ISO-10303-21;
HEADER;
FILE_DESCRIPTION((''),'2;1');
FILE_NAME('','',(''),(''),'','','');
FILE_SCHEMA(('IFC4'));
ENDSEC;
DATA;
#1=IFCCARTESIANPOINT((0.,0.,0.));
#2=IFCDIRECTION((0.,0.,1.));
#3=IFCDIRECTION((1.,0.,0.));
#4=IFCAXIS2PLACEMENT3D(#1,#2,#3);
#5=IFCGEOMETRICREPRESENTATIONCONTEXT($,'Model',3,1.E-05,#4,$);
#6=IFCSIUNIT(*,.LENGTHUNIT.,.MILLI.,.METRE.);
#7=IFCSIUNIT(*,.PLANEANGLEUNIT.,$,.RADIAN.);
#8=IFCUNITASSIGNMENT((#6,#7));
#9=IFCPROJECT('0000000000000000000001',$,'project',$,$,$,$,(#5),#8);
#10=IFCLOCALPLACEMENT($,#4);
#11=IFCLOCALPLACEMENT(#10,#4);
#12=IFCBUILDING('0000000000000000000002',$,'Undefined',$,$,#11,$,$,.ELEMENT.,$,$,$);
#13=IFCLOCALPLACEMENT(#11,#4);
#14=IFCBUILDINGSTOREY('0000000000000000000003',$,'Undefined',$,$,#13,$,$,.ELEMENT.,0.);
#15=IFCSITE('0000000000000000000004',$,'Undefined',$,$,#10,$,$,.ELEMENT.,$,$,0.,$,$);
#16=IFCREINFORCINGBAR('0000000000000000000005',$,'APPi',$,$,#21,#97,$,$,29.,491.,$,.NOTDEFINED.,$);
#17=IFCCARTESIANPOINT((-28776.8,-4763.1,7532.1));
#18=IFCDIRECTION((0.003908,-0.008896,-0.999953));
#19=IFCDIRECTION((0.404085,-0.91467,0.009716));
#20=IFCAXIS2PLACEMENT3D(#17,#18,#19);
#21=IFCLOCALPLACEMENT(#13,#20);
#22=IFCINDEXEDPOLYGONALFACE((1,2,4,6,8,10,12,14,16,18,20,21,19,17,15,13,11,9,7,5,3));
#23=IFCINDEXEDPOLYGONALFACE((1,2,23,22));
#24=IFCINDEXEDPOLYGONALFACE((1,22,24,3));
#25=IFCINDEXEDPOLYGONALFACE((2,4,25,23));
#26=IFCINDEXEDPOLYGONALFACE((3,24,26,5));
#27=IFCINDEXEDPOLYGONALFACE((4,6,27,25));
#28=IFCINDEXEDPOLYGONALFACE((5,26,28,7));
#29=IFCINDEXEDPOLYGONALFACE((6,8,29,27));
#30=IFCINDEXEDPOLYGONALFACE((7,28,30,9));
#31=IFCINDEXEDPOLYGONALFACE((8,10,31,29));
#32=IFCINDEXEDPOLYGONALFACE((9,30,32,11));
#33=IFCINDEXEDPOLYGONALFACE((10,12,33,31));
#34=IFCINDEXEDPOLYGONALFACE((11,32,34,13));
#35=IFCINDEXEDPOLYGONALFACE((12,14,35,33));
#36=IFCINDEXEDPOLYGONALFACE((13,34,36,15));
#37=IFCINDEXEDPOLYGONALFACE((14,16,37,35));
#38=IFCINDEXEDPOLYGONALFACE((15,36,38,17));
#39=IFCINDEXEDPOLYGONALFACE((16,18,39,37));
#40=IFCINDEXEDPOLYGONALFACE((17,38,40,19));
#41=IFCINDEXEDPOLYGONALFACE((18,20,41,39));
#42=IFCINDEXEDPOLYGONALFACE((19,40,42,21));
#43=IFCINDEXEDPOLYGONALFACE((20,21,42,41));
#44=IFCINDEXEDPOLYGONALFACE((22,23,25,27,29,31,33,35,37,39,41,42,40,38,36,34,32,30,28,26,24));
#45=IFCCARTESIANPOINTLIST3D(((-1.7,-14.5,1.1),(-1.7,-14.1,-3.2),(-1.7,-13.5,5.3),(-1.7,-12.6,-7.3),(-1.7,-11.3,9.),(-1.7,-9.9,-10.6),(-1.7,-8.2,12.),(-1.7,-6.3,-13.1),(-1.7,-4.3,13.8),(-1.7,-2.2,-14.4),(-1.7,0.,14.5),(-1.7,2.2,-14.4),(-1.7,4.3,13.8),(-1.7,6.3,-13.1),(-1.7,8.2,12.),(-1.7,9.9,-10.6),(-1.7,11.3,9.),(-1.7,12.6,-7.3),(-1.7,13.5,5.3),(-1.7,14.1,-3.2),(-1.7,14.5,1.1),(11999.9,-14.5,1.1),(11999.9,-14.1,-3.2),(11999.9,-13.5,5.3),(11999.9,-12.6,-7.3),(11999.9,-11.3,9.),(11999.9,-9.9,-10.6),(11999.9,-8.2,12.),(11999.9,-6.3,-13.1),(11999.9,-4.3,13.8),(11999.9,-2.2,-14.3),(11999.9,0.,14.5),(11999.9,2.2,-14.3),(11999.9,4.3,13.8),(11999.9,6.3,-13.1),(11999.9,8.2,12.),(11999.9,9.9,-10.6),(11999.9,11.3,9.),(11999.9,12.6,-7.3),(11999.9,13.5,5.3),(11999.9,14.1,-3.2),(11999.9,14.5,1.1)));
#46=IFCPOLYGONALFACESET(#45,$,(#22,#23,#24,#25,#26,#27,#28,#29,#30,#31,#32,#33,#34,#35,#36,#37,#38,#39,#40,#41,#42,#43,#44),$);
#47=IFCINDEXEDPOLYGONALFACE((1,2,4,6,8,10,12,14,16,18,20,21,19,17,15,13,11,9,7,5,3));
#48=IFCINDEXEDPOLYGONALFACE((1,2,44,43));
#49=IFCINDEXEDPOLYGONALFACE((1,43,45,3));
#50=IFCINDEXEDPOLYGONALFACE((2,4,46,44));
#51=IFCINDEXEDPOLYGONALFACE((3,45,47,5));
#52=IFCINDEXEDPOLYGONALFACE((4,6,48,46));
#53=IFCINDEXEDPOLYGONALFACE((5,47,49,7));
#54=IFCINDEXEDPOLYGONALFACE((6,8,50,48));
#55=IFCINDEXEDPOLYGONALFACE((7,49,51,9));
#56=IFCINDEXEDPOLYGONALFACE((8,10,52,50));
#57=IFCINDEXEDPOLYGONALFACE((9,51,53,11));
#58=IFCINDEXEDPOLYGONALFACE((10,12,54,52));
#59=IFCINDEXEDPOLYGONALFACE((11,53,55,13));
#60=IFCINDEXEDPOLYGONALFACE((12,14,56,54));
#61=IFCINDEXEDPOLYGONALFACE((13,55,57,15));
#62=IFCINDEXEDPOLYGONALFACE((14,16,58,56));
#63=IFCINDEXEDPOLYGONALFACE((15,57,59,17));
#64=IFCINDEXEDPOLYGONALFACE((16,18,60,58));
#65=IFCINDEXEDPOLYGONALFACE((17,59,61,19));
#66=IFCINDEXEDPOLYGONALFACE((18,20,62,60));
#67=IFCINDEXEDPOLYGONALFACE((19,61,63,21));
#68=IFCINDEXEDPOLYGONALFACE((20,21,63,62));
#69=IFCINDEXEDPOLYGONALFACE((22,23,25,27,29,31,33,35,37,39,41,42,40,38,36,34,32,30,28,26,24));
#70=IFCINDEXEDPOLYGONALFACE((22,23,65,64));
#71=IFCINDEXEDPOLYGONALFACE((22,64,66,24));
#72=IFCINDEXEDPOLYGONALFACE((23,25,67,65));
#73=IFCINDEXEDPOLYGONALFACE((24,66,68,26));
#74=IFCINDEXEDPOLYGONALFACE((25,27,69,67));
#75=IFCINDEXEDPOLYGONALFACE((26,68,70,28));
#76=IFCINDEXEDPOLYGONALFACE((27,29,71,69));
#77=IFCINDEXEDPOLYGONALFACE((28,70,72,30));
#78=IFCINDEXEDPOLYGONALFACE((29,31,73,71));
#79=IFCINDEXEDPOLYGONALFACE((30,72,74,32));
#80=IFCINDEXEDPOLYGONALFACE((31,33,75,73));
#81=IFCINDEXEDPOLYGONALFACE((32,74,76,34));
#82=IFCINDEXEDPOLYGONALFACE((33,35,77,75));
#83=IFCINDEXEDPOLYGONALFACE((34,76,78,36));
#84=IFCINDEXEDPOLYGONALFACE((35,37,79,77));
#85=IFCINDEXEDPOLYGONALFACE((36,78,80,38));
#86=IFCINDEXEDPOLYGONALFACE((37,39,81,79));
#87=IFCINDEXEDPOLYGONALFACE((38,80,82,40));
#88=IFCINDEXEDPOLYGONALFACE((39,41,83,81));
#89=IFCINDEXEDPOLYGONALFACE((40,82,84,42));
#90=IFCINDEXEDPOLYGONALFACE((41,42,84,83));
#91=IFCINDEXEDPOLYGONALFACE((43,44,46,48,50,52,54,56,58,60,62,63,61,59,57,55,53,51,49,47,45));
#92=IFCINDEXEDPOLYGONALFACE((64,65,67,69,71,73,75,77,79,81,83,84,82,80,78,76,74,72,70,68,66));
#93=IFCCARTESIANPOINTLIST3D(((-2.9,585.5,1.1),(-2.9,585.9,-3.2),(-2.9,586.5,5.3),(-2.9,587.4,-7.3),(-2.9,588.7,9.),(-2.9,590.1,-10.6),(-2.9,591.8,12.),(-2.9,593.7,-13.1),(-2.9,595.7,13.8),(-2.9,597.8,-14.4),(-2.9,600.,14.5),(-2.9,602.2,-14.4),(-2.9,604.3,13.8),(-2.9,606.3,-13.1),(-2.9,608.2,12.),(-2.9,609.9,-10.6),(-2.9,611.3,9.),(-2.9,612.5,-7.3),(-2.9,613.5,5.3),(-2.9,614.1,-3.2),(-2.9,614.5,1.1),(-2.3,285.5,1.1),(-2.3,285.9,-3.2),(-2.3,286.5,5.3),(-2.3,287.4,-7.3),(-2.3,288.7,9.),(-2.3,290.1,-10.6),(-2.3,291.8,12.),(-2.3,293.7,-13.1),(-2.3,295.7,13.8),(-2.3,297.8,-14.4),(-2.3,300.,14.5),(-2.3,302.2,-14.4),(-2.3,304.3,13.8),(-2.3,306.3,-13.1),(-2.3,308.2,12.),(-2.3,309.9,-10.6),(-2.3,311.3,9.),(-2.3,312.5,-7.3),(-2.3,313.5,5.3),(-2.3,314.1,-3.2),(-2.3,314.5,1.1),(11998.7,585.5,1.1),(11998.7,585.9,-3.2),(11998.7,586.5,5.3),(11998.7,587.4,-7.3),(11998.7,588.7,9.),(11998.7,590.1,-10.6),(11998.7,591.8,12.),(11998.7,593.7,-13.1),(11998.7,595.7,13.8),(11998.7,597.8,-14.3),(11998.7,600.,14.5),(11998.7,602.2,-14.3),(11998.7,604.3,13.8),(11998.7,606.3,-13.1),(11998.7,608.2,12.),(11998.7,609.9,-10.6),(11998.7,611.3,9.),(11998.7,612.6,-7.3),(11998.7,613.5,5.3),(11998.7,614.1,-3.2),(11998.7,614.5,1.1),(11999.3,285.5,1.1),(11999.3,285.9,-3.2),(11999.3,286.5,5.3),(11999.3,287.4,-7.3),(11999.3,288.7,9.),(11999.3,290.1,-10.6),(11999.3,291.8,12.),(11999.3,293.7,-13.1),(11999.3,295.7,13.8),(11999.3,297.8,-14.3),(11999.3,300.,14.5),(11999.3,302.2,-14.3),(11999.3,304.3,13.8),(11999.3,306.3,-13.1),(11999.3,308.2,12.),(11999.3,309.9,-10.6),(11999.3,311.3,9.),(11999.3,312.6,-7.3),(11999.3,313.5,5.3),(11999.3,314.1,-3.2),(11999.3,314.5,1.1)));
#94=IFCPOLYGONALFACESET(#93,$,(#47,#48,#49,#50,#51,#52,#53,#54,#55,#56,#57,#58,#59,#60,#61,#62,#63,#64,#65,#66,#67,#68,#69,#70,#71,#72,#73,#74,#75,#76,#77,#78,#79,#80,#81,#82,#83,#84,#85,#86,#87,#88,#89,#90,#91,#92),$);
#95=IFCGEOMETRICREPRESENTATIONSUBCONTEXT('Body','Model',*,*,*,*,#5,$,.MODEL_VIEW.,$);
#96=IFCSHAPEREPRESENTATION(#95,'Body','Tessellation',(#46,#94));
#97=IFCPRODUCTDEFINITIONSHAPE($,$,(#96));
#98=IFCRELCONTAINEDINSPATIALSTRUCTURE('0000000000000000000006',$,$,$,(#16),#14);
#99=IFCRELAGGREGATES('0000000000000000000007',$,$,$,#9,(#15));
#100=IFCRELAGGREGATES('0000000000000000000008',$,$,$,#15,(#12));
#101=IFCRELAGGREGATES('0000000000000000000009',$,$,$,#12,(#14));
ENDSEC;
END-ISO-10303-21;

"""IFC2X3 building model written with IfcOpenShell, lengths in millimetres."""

from ifc_helpers import new_model, entity, si_unit, frame, origin_with_axes, place, context, subcontext, project, spatial, source, transform, mapped, element, save


model = new_model("IFC2X3")

# Units and contexts
model_context = context("Model", 3, precision=1e-05, world=origin_with_axes())
body_context = subcontext(model_context, "Body", "Model", "MODEL_VIEW")
ifc_project = project(units=[si_unit("LENGTHUNIT", "METRE", prefix="MILLI"), si_unit("PLANEANGLEUNIT", "RADIAN")], contexts=[model_context])

# Site, building, storey
site_placement = place(None, origin_with_axes())
site = spatial("IfcSite", under=ifc_project, at=site_placement, Name="Undefined", CompositionType="ELEMENT", RefElevation=0.0)
building_placement = place(site_placement, origin_with_axes())
building = spatial("IfcBuilding", under=site, at=building_placement, Name="Undefined", CompositionType="ELEMENT")
storey_placement = place(building_placement, origin_with_axes())
storey = spatial("IfcBuildingStorey", under=building, at=storey_placement, Name="Undefined", CompositionType="ELEMENT", Elevation=0.0)

# Reinforcing bar
shared_shape_1 = source(origin_with_axes(), body_context, "Body", "AdvancedSweptSolid", [
    entity("IfcSweptDiskSolid", entity("IfcTrimmedCurve", entity("IfcLine", entity("IfcCartesianPoint", [0.0, 0.0, 0.0]), entity("IfcVector", entity("IfcDirection", [1.0, 0.0, 0.000001]), 1.0)), [entity("IfcParameterValue", 0.0)], [entity("IfcParameterValue", 12001.59824)], True, "PARAMETER"), 14.5, None, 0.0, 12001.6),
])
shared_shape_2 = source(origin_with_axes(), body_context, "Body", "AdvancedSweptSolid", [
    entity("IfcSweptDiskSolid", entity("IfcTrimmedCurve", entity("IfcLine", entity("IfcCartesianPoint", [0.0, 0.0, 0.0]), entity("IfcVector", entity("IfcDirection", [1.0, 0.0, 0.000001]), 1.0)), [entity("IfcParameterValue", 0.0)], [entity("IfcParameterValue", 12001.59824)], True, "PARAMETER"), 14.5, None, 0.0, 12001.6),
])
shared_shape_3 = source(origin_with_axes(), body_context, "Body", "AdvancedSweptSolid", [
    entity("IfcSweptDiskSolid", entity("IfcTrimmedCurve", entity("IfcLine", entity("IfcCartesianPoint", [0.0, 0.0, 0.0]), entity("IfcVector", entity("IfcDirection", [1.0, 0.0, 0.000001]), 1.0)), [entity("IfcParameterValue", 0.0)], [entity("IfcParameterValue", 12001.59824)], True, "PARAMETER"), 14.5, None, 0.0, 12001.6),
])
reinforcing_bar_1_placement = place(storey_placement, frame((-28776.8, -4763.1, 7532.1), z_axis=(0.003908, -0.008896, -0.999953), x_axis=(0.404085, -0.91467, 0.009716)))
element("IfcReinforcingBar", 1, at=reinforcing_bar_1_placement, inside=storey, Name="APPi", BarRole="NOTDEFINED", CrossSectionArea=491.0, NominalDiameter=29.0, context=body_context, shape_type="MappedRepresentation", body=[
    mapped(shared_shape_1, transform((-1.7, 0.0, 0.0))),
    mapped(shared_shape_2, transform((-2.3, 300.0, 0.0))),
    mapped(shared_shape_3, transform((-2.9, 600.0, 0.0))),
])

save(model, "model.ifc")
